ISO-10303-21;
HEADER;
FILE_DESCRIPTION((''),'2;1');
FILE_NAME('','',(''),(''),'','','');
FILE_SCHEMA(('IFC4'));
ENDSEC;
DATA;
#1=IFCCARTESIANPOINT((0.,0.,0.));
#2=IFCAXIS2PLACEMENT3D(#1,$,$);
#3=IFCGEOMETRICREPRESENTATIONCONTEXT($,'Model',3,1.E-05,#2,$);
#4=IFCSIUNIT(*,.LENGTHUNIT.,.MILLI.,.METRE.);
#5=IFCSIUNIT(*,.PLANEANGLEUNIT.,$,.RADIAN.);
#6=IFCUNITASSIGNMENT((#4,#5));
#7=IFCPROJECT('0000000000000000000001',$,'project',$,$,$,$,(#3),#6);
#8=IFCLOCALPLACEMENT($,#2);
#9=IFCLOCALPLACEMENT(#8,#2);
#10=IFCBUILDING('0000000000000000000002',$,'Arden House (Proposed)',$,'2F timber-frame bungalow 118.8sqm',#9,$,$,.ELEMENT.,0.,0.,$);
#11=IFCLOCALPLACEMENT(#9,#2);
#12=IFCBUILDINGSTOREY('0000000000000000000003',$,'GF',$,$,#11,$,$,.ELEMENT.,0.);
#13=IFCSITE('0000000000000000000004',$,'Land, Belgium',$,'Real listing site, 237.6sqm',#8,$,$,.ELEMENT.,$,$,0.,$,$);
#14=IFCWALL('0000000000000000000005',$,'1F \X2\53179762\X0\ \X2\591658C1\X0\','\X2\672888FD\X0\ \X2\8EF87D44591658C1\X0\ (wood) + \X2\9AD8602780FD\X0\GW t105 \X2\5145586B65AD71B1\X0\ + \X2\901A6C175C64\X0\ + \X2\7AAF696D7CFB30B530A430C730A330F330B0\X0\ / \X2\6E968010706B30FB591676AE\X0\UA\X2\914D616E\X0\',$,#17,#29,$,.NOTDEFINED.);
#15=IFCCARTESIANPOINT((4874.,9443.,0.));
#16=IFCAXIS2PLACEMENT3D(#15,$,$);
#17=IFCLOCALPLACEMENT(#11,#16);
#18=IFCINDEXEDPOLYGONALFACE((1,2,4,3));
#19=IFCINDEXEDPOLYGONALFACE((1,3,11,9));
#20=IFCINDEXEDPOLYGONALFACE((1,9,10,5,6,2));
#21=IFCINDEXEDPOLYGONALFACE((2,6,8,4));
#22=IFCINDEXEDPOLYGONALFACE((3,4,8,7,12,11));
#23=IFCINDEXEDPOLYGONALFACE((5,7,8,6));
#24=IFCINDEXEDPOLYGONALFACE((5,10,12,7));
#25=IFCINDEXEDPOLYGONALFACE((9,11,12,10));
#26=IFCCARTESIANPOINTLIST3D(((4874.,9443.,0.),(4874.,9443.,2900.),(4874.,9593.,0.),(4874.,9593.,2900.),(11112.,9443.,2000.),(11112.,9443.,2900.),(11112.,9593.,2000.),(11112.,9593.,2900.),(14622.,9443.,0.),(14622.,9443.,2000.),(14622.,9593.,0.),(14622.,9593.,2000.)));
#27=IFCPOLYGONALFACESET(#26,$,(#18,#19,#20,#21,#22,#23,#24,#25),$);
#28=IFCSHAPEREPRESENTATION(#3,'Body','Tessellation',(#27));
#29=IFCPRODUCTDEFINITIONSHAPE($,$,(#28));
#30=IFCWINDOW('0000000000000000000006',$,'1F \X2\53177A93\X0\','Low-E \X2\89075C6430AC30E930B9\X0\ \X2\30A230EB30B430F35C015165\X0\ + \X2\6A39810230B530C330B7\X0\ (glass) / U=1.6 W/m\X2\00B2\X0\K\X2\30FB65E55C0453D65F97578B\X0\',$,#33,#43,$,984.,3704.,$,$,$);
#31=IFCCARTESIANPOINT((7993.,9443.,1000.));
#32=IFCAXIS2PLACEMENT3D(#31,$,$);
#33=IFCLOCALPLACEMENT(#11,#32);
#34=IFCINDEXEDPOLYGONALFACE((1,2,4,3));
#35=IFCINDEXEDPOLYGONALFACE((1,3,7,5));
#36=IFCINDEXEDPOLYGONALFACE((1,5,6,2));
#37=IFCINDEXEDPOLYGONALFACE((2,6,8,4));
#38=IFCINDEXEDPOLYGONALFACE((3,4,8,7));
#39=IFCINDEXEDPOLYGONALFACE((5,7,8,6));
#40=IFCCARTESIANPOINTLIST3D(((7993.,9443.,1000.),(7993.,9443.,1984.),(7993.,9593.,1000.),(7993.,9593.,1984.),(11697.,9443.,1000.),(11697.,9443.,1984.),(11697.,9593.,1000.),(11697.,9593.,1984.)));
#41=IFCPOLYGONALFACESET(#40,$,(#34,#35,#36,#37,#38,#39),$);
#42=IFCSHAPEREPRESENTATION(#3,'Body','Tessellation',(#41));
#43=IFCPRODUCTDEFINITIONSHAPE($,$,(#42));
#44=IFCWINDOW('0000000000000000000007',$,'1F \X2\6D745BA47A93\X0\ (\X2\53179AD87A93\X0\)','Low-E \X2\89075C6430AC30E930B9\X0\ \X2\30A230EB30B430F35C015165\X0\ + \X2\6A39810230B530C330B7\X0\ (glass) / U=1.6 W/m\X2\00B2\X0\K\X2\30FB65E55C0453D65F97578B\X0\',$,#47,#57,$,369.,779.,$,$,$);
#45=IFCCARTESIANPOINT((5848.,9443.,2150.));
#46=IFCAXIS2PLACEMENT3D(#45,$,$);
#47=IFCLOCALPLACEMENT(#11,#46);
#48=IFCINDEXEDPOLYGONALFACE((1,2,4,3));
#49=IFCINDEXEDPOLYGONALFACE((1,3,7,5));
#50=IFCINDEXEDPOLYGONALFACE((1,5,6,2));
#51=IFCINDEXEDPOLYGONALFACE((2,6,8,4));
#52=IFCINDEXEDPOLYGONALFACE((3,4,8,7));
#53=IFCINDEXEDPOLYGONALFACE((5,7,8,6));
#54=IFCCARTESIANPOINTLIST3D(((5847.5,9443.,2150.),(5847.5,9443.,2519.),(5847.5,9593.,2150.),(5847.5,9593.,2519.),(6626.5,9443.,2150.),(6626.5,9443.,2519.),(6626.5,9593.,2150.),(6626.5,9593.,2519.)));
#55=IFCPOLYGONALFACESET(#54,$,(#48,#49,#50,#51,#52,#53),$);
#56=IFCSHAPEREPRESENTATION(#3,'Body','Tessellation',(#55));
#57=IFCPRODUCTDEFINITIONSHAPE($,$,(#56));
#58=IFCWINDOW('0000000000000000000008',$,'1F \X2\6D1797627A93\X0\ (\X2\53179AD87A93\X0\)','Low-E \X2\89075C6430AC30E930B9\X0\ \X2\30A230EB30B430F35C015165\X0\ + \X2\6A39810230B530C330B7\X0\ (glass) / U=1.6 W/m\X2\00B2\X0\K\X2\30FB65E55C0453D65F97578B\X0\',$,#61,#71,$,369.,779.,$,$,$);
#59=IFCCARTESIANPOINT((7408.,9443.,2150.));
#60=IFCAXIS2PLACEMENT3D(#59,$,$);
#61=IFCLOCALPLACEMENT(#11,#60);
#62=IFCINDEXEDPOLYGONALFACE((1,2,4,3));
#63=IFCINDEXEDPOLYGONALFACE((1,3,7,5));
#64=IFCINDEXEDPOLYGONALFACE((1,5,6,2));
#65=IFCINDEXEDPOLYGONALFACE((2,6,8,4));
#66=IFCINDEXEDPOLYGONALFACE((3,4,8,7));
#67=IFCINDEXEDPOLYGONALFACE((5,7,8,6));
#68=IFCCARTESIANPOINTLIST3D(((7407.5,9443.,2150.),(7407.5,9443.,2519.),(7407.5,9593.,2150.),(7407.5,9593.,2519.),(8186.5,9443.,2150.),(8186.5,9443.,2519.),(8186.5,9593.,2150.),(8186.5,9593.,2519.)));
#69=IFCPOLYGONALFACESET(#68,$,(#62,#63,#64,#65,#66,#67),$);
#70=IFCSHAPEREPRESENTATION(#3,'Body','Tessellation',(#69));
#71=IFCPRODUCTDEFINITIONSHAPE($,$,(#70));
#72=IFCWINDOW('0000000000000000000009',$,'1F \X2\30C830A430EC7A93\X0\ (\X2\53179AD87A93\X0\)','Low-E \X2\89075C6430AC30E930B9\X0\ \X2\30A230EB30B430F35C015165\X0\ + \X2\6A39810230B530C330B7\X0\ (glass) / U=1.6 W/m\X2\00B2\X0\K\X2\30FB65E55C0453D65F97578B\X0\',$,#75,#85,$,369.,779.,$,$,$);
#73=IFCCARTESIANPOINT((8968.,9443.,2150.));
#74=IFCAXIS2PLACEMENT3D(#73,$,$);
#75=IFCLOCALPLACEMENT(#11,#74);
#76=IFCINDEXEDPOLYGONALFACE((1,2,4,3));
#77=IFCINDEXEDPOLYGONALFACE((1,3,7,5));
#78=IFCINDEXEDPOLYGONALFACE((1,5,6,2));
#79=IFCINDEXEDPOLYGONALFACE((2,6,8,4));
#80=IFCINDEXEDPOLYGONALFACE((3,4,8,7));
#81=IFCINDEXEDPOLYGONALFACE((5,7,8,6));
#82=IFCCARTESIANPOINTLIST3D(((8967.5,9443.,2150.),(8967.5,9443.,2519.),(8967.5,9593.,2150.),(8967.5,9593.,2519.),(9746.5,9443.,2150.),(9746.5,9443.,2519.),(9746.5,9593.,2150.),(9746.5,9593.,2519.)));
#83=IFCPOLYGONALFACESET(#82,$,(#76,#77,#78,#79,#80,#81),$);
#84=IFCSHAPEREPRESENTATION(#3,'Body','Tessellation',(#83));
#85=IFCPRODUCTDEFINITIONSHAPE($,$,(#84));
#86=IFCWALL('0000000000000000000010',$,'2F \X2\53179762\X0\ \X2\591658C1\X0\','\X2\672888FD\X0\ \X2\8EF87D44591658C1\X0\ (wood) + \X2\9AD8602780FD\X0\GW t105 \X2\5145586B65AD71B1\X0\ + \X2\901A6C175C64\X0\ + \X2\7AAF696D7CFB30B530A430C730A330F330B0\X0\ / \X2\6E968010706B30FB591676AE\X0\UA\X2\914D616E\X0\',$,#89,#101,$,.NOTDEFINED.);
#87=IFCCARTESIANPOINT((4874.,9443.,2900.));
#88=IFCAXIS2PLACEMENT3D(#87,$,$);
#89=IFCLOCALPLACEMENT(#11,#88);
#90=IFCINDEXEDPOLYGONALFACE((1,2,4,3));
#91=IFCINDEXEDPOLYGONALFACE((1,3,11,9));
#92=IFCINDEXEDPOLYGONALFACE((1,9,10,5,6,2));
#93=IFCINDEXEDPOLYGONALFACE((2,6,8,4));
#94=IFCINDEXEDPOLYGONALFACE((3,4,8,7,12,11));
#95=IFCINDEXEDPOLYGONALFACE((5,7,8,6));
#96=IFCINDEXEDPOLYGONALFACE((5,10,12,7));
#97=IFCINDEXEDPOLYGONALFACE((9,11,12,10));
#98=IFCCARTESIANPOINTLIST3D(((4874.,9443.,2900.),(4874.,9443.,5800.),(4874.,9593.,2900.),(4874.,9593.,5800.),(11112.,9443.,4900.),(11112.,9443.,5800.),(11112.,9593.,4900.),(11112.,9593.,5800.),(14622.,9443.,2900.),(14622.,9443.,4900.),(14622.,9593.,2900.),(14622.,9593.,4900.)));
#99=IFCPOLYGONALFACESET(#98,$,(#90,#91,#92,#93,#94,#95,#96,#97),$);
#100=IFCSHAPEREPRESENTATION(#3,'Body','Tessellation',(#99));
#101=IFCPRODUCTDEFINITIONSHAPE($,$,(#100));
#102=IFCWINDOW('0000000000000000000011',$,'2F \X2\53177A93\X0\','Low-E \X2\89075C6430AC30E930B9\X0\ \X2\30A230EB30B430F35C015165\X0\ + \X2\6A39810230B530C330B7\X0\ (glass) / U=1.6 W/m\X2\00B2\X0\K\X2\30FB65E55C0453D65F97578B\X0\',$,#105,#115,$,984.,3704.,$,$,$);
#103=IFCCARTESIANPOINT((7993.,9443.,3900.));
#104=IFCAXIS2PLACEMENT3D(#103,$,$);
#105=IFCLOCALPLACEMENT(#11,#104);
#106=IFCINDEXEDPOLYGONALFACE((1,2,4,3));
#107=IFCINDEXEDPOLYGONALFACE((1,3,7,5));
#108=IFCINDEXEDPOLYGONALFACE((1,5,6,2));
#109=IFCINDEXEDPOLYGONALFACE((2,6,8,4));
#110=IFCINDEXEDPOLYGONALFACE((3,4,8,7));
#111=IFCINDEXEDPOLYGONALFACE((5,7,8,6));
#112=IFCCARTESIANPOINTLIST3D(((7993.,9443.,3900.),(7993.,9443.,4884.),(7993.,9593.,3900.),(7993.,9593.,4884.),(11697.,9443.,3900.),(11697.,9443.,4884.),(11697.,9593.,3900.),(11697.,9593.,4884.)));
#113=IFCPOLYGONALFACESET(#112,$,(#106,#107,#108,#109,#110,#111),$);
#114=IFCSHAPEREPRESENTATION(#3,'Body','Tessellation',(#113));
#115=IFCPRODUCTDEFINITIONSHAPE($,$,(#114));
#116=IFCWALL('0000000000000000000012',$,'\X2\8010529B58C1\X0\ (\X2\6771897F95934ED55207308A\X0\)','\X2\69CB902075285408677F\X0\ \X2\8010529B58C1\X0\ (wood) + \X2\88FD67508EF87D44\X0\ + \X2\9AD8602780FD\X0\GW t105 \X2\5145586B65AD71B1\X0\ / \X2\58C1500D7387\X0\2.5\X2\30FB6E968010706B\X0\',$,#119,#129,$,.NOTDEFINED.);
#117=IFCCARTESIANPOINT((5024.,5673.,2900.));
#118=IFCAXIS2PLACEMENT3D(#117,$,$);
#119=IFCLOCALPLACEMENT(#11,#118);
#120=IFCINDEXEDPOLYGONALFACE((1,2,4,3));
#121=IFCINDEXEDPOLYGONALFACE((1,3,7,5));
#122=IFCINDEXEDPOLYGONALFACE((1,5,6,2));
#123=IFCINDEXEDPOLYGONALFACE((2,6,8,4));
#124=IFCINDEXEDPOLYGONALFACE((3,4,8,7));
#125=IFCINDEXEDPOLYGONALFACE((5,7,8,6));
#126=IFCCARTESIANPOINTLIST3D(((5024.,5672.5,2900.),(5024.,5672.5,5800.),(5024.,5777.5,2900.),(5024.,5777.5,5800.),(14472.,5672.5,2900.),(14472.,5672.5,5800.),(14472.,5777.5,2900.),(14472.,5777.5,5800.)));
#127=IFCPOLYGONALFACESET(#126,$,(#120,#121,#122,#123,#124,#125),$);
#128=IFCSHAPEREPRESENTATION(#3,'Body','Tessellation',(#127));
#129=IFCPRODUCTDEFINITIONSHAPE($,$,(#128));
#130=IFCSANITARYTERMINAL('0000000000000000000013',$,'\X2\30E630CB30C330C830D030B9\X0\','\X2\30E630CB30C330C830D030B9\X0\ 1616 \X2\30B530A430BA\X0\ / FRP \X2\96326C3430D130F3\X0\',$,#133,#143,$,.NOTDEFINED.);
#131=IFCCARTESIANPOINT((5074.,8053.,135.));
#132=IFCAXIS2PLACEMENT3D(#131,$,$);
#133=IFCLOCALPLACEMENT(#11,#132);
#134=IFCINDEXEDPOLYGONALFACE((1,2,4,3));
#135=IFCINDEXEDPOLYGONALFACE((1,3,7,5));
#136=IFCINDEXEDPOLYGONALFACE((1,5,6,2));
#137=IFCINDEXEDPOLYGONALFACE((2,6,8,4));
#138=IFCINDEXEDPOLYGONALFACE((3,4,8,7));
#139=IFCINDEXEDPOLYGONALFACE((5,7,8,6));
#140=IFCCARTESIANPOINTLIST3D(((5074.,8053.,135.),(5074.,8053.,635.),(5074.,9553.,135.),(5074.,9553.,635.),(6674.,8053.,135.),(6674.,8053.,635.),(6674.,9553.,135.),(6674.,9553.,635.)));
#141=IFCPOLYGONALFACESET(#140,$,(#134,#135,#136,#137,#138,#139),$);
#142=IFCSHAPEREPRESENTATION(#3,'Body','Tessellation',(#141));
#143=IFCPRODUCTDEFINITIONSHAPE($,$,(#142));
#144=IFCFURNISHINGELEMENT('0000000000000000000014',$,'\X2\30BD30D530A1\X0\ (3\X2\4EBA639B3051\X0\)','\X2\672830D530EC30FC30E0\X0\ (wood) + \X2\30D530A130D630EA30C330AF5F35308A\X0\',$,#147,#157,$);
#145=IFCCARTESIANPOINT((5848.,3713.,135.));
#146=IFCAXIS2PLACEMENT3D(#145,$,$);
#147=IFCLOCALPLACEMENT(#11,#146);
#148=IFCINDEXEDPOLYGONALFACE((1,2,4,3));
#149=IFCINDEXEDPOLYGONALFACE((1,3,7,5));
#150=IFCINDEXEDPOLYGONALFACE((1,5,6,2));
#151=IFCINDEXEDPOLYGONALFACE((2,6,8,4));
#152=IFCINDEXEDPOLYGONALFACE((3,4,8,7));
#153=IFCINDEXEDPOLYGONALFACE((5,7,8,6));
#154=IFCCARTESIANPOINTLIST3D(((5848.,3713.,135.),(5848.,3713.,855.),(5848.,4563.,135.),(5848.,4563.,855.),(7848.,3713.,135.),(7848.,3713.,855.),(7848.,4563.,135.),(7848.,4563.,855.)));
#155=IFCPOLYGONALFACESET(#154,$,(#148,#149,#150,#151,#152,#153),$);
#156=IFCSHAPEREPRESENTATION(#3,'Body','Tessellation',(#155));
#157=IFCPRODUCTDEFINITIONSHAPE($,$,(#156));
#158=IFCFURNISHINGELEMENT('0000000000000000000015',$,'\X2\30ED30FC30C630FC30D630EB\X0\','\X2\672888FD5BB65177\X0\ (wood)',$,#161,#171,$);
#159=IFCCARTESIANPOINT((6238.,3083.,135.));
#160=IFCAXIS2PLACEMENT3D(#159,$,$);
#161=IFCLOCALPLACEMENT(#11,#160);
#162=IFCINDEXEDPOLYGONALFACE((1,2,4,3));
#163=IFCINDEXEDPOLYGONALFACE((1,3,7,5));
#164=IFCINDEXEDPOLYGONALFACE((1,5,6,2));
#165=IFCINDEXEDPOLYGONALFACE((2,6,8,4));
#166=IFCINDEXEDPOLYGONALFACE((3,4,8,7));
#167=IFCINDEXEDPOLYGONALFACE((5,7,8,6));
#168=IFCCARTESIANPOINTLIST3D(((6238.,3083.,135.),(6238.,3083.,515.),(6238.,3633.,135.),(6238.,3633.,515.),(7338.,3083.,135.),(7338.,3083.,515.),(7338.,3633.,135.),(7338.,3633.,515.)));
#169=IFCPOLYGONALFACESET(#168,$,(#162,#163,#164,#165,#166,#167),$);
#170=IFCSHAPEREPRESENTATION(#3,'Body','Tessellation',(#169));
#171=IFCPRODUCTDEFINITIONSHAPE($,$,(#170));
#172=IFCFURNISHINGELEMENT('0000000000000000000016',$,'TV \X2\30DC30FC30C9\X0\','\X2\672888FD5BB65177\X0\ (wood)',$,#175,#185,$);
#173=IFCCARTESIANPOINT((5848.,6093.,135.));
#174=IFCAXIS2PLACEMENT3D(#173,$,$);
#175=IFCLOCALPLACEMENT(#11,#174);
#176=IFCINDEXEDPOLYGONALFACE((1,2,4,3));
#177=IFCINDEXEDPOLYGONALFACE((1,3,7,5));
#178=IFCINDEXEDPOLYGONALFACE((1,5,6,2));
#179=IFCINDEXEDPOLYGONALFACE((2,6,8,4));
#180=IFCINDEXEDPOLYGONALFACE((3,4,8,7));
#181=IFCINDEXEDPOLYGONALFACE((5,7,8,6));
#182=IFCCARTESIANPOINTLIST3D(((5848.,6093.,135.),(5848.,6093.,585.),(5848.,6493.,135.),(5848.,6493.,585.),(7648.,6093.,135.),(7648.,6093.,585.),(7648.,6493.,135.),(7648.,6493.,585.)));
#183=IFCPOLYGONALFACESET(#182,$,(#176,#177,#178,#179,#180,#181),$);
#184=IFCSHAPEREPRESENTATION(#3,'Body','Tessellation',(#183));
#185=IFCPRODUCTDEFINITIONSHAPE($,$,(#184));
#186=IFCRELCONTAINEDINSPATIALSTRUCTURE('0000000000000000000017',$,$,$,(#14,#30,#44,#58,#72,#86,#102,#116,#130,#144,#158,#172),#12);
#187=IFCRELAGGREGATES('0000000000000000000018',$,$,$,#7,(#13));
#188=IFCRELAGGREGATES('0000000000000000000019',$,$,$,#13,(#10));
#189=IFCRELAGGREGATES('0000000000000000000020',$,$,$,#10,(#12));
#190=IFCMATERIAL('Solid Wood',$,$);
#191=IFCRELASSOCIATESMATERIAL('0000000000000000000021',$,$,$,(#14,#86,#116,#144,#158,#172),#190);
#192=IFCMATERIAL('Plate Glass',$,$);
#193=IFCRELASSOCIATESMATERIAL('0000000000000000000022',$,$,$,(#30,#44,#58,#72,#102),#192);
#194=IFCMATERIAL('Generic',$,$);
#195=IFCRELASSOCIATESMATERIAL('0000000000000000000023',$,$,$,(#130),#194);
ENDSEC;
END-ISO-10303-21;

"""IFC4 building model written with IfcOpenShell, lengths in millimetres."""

from ifc_helpers import new_model, si_unit, frame, frame_2d, origin, place, context, project, spatial, rectangle, extrude, material, element, fill, save


model = new_model("IFC4")

# Units and contexts
model_context = context("Model", 3, precision=1e-05, world=origin())
ifc_project = project(units=[si_unit("LENGTHUNIT", "METRE", prefix="MILLI"), si_unit("PLANEANGLEUNIT", "RADIAN")], contexts=[model_context])

# Site, building, storey
site_placement = place(None, origin())
site = spatial("IfcSite", under=ifc_project, at=site_placement, Name="Land, Belgium", ObjectType="Real listing site, 237.6sqm", CompositionType="ELEMENT", RefElevation=0.0)
building_placement = place(site_placement, origin())
building = spatial("IfcBuilding", under=site, at=building_placement, Name="Arden House (Proposed)", ObjectType="2F timber-frame bungalow 118.8sqm", CompositionType="ELEMENT", ElevationOfRefHeight=0.0, ElevationOfTerrain=0.0)
storey_placement = place(building_placement, origin())
storey = spatial("IfcBuildingStorey", under=building, at=storey_placement, Name="GF", CompositionType="ELEMENT", Elevation=0.0)

# Wall, openings, windows
ifc_material_1 = material(Name="Solid Wood")
wall_1_placement = place(storey_placement, frame((4874.0, 9443.0, 0.0)))
wall_1 = element("IfcWall", 1, at=wall_1_placement, inside=storey, material=ifc_material_1, Name="1F 北面 外壁", Description="木製 軸組外壁 (wood) + 高性能GW t105 充填断熱 + 通気層 + 窯業系サイディング / 準耐火・外皮UA配慮", PredefinedType="NOTDEFINED", context=model_context, shape_type="SweptSolid", body=[
    extrude(rectangle(XDim=9748.0, YDim=150.0, at=frame_2d((4874.0, 75.0))), frame((4874.0, 9443.0, 0.0)), (0.0, 0.0, 1.0), 2900.0),
])
opening_1_placement = place(storey_placement, frame((7993.0, 9443.0, 1000.0)))
opening_1 = element("IfcOpeningElement", 2, at=opening_1_placement, cuts=wall_1, PredefinedType="NOTDEFINED", context=model_context, shape_type="SweptSolid", body=[
    extrude(rectangle(XDim=3704.0, YDim=150.0, at=frame_2d((1852.0, 75.0))), frame((7993.0, 9443.0, 1000.0)), (0.0, 0.0, 1.0), 984.0),
])
opening_2_placement = place(storey_placement, frame((5848.0, 9443.0, 2150.0)))
opening_2 = element("IfcOpeningElement", 3, at=opening_2_placement, cuts=wall_1, PredefinedType="NOTDEFINED", context=model_context, shape_type="SweptSolid", body=[
    extrude(rectangle(XDim=779.0, YDim=150.0, at=frame_2d((389.0, 75.0))), frame((5848.0, 9443.0, 2150.0)), (0.0, 0.0, 1.0), 369.0),
])
opening_3_placement = place(storey_placement, frame((7408.0, 9443.0, 2150.0)))
opening_3 = element("IfcOpeningElement", 4, at=opening_3_placement, cuts=wall_1, PredefinedType="NOTDEFINED", context=model_context, shape_type="SweptSolid", body=[
    extrude(rectangle(XDim=779.0, YDim=150.0, at=frame_2d((389.0, 75.0))), frame((7408.0, 9443.0, 2150.0)), (0.0, 0.0, 1.0), 369.0),
])
opening_4_placement = place(storey_placement, frame((8968.0, 9443.0, 2150.0)))
opening_4 = element("IfcOpeningElement", 5, at=opening_4_placement, cuts=wall_1, PredefinedType="NOTDEFINED", context=model_context, shape_type="SweptSolid", body=[
    extrude(rectangle(XDim=779.0, YDim=150.0, at=frame_2d((389.0, 75.0))), frame((8968.0, 9443.0, 2150.0)), (0.0, 0.0, 1.0), 369.0),
])
ifc_material_2 = material(Name="Plate Glass")
window_1_placement = place(storey_placement, frame((7993.0, 9443.0, 1000.0)))
window_1 = element("IfcWindow", 6, at=window_1_placement, inside=storey, material=ifc_material_2, Name="1F 北窓", Description="Low-E 複層ガラス アルゴン封入 + 樹脂サッシ (glass) / U=1.6 W/m²K・日射取得型", OverallHeight=984.0, OverallWidth=3704.0, context=model_context, shape_type="SweptSolid", body=[
    extrude(rectangle(XDim=3704.0, YDim=150.0, at=frame_2d((1852.0, 75.0))), frame((7993.0, 9443.0, 1000.0)), (0.0, 0.0, 1.0), 984.0),
])
fill(opening_1, window_1)
window_2_placement = place(storey_placement, frame((5848.0, 9443.0, 2150.0)))
window_2 = element("IfcWindow", 7, at=window_2_placement, inside=storey, material=ifc_material_2, Name="1F 浴室窓 (北高窓)", Description="Low-E 複層ガラス アルゴン封入 + 樹脂サッシ (glass) / U=1.6 W/m²K・日射取得型", OverallHeight=369.0, OverallWidth=779.0, context=model_context, shape_type="SweptSolid", body=[
    extrude(rectangle(XDim=779.0, YDim=150.0, at=frame_2d((389.0, 75.0))), frame((5848.0, 9443.0, 2150.0)), (0.0, 0.0, 1.0), 369.0),
])
fill(opening_2, window_2)
window_3_placement = place(storey_placement, frame((7408.0, 9443.0, 2150.0)))
window_3 = element("IfcWindow", 8, at=window_3_placement, inside=storey, material=ifc_material_2, Name="1F 洗面窓 (北高窓)", Description="Low-E 複層ガラス アルゴン封入 + 樹脂サッシ (glass) / U=1.6 W/m²K・日射取得型", OverallHeight=369.0, OverallWidth=779.0, context=model_context, shape_type="SweptSolid", body=[
    extrude(rectangle(XDim=779.0, YDim=150.0, at=frame_2d((389.0, 75.0))), frame((7408.0, 9443.0, 2150.0)), (0.0, 0.0, 1.0), 369.0),
])
fill(opening_3, window_3)
window_4_placement = place(storey_placement, frame((8968.0, 9443.0, 2150.0)))
window_4 = element("IfcWindow", 9, at=window_4_placement, inside=storey, material=ifc_material_2, Name="1F トイレ窓 (北高窓)", Description="Low-E 複層ガラス アルゴン封入 + 樹脂サッシ (glass) / U=1.6 W/m²K・日射取得型", OverallHeight=369.0, OverallWidth=779.0, context=model_context, shape_type="SweptSolid", body=[
    extrude(rectangle(XDim=779.0, YDim=150.0, at=frame_2d((389.0, 75.0))), frame((8968.0, 9443.0, 2150.0)), (0.0, 0.0, 1.0), 369.0),
])
fill(opening_4, window_4)

# Wall, opening, window
wall_2_placement = place(storey_placement, frame((4874.0, 9443.0, 2900.0)))
wall_2 = element("IfcWall", 10, at=wall_2_placement, inside=storey, material=ifc_material_1, Name="2F 北面 外壁", Description="木製 軸組外壁 (wood) + 高性能GW t105 充填断熱 + 通気層 + 窯業系サイディング / 準耐火・外皮UA配慮", PredefinedType="NOTDEFINED", context=model_context, shape_type="SweptSolid", body=[
    extrude(rectangle(XDim=9748.0, YDim=150.0, at=frame_2d((4874.0, 75.0))), frame((4874.0, 9443.0, 2900.0)), (0.0, 0.0, 1.0), 2900.0),
])
opening_5_placement = place(storey_placement, frame((7993.0, 9443.0, 3900.0)))
opening_5 = element("IfcOpeningElement", 11, at=opening_5_placement, cuts=wall_2, PredefinedType="NOTDEFINED", context=model_context, shape_type="SweptSolid", body=[
    extrude(rectangle(XDim=3704.0, YDim=150.0, at=frame_2d((1852.0, 75.0))), frame((7993.0, 9443.0, 3900.0)), (0.0, 0.0, 1.0), 984.0),
])
window_5_placement = place(storey_placement, frame((7993.0, 9443.0, 3900.0)))
window_5 = element("IfcWindow", 12, at=window_5_placement, inside=storey, material=ifc_material_2, Name="2F 北窓", Description="Low-E 複層ガラス アルゴン封入 + 樹脂サッシ (glass) / U=1.6 W/m²K・日射取得型", OverallHeight=984.0, OverallWidth=3704.0, context=model_context, shape_type="SweptSolid", body=[
    extrude(rectangle(XDim=3704.0, YDim=150.0, at=frame_2d((1852.0, 75.0))), frame((7993.0, 9443.0, 3900.0)), (0.0, 0.0, 1.0), 984.0),
])
fill(opening_5, window_5)

# Wall
wall_3_placement = place(storey_placement, frame((5024.0, 5673.0, 2900.0)))
element("IfcWall", 13, at=wall_3_placement, inside=storey, material=ifc_material_1, Name="耐力壁 (東西間仕切り)", Description="構造用合板 耐力壁 (wood) + 製材軸組 + 高性能GW t105 充填断熱 / 壁倍率2.5・準耐火", PredefinedType="NOTDEFINED", context=model_context, shape_type="SweptSolid", body=[
    extrude(rectangle(XDim=9448.0, YDim=105.0, at=frame_2d((4724.0, 52.0))), frame((5024.0, 5673.0, 2900.0)), (0.0, 0.0, 1.0), 2900.0),
])

# Sanitary terminal
ifc_material_3 = material(Name="Generic")
sanitary_terminal_placement = place(storey_placement, frame((5074.0, 8053.0, 135.0)))
element("IfcSanitaryTerminal", 14, at=sanitary_terminal_placement, inside=storey, material=ifc_material_3, Name="ユニットバス", Description="ユニットバス 1616 サイズ / FRP 防水パン", PredefinedType="NOTDEFINED", context=model_context, shape_type="SweptSolid", body=[
    extrude(rectangle(XDim=1600.0, YDim=1500.0, at=frame_2d((800.0, 750.0))), frame((5074.0, 8053.0, 135.0)), (0.0, 0.0, 1.0), 500.0),
])

# Furnishing elements
furnishing_1_placement = place(storey_placement, frame((5848.0, 3713.0, 135.0)))
element("IfcFurnishingElement", 15, at=furnishing_1_placement, inside=storey, material=ifc_material_1, Name="ソファ (3人掛け)", Description="木フレーム (wood) + ファブリック張り", context=model_context, shape_type="SweptSolid", body=[
    extrude(rectangle(XDim=2000.0, YDim=850.0, at=frame_2d((1000.0, 425.0))), frame((5848.0, 3713.0, 135.0)), (0.0, 0.0, 1.0), 720.0),
])
furnishing_2_placement = place(storey_placement, frame((6238.0, 3083.0, 135.0)))
element("IfcFurnishingElement", 16, at=furnishing_2_placement, inside=storey, material=ifc_material_1, Name="ローテーブル", Description="木製家具 (wood)", context=model_context, shape_type="SweptSolid", body=[
    extrude(rectangle(XDim=1100.0, YDim=550.0, at=frame_2d((550.0, 275.0))), frame((6238.0, 3083.0, 135.0)), (0.0, 0.0, 1.0), 380.0),
])
furnishing_3_placement = place(storey_placement, frame((5848.0, 6093.0, 135.0)))
element("IfcFurnishingElement", 17, at=furnishing_3_placement, inside=storey, material=ifc_material_1, Name="TV ボード", Description="木製家具 (wood)", context=model_context, shape_type="SweptSolid", body=[
    extrude(rectangle(XDim=1800.0, YDim=400.0, at=frame_2d((900.0, 200.0))), frame((5848.0, 6093.0, 135.0)), (0.0, 0.0, 1.0), 450.0),
])

save(model, "model.ifc")
